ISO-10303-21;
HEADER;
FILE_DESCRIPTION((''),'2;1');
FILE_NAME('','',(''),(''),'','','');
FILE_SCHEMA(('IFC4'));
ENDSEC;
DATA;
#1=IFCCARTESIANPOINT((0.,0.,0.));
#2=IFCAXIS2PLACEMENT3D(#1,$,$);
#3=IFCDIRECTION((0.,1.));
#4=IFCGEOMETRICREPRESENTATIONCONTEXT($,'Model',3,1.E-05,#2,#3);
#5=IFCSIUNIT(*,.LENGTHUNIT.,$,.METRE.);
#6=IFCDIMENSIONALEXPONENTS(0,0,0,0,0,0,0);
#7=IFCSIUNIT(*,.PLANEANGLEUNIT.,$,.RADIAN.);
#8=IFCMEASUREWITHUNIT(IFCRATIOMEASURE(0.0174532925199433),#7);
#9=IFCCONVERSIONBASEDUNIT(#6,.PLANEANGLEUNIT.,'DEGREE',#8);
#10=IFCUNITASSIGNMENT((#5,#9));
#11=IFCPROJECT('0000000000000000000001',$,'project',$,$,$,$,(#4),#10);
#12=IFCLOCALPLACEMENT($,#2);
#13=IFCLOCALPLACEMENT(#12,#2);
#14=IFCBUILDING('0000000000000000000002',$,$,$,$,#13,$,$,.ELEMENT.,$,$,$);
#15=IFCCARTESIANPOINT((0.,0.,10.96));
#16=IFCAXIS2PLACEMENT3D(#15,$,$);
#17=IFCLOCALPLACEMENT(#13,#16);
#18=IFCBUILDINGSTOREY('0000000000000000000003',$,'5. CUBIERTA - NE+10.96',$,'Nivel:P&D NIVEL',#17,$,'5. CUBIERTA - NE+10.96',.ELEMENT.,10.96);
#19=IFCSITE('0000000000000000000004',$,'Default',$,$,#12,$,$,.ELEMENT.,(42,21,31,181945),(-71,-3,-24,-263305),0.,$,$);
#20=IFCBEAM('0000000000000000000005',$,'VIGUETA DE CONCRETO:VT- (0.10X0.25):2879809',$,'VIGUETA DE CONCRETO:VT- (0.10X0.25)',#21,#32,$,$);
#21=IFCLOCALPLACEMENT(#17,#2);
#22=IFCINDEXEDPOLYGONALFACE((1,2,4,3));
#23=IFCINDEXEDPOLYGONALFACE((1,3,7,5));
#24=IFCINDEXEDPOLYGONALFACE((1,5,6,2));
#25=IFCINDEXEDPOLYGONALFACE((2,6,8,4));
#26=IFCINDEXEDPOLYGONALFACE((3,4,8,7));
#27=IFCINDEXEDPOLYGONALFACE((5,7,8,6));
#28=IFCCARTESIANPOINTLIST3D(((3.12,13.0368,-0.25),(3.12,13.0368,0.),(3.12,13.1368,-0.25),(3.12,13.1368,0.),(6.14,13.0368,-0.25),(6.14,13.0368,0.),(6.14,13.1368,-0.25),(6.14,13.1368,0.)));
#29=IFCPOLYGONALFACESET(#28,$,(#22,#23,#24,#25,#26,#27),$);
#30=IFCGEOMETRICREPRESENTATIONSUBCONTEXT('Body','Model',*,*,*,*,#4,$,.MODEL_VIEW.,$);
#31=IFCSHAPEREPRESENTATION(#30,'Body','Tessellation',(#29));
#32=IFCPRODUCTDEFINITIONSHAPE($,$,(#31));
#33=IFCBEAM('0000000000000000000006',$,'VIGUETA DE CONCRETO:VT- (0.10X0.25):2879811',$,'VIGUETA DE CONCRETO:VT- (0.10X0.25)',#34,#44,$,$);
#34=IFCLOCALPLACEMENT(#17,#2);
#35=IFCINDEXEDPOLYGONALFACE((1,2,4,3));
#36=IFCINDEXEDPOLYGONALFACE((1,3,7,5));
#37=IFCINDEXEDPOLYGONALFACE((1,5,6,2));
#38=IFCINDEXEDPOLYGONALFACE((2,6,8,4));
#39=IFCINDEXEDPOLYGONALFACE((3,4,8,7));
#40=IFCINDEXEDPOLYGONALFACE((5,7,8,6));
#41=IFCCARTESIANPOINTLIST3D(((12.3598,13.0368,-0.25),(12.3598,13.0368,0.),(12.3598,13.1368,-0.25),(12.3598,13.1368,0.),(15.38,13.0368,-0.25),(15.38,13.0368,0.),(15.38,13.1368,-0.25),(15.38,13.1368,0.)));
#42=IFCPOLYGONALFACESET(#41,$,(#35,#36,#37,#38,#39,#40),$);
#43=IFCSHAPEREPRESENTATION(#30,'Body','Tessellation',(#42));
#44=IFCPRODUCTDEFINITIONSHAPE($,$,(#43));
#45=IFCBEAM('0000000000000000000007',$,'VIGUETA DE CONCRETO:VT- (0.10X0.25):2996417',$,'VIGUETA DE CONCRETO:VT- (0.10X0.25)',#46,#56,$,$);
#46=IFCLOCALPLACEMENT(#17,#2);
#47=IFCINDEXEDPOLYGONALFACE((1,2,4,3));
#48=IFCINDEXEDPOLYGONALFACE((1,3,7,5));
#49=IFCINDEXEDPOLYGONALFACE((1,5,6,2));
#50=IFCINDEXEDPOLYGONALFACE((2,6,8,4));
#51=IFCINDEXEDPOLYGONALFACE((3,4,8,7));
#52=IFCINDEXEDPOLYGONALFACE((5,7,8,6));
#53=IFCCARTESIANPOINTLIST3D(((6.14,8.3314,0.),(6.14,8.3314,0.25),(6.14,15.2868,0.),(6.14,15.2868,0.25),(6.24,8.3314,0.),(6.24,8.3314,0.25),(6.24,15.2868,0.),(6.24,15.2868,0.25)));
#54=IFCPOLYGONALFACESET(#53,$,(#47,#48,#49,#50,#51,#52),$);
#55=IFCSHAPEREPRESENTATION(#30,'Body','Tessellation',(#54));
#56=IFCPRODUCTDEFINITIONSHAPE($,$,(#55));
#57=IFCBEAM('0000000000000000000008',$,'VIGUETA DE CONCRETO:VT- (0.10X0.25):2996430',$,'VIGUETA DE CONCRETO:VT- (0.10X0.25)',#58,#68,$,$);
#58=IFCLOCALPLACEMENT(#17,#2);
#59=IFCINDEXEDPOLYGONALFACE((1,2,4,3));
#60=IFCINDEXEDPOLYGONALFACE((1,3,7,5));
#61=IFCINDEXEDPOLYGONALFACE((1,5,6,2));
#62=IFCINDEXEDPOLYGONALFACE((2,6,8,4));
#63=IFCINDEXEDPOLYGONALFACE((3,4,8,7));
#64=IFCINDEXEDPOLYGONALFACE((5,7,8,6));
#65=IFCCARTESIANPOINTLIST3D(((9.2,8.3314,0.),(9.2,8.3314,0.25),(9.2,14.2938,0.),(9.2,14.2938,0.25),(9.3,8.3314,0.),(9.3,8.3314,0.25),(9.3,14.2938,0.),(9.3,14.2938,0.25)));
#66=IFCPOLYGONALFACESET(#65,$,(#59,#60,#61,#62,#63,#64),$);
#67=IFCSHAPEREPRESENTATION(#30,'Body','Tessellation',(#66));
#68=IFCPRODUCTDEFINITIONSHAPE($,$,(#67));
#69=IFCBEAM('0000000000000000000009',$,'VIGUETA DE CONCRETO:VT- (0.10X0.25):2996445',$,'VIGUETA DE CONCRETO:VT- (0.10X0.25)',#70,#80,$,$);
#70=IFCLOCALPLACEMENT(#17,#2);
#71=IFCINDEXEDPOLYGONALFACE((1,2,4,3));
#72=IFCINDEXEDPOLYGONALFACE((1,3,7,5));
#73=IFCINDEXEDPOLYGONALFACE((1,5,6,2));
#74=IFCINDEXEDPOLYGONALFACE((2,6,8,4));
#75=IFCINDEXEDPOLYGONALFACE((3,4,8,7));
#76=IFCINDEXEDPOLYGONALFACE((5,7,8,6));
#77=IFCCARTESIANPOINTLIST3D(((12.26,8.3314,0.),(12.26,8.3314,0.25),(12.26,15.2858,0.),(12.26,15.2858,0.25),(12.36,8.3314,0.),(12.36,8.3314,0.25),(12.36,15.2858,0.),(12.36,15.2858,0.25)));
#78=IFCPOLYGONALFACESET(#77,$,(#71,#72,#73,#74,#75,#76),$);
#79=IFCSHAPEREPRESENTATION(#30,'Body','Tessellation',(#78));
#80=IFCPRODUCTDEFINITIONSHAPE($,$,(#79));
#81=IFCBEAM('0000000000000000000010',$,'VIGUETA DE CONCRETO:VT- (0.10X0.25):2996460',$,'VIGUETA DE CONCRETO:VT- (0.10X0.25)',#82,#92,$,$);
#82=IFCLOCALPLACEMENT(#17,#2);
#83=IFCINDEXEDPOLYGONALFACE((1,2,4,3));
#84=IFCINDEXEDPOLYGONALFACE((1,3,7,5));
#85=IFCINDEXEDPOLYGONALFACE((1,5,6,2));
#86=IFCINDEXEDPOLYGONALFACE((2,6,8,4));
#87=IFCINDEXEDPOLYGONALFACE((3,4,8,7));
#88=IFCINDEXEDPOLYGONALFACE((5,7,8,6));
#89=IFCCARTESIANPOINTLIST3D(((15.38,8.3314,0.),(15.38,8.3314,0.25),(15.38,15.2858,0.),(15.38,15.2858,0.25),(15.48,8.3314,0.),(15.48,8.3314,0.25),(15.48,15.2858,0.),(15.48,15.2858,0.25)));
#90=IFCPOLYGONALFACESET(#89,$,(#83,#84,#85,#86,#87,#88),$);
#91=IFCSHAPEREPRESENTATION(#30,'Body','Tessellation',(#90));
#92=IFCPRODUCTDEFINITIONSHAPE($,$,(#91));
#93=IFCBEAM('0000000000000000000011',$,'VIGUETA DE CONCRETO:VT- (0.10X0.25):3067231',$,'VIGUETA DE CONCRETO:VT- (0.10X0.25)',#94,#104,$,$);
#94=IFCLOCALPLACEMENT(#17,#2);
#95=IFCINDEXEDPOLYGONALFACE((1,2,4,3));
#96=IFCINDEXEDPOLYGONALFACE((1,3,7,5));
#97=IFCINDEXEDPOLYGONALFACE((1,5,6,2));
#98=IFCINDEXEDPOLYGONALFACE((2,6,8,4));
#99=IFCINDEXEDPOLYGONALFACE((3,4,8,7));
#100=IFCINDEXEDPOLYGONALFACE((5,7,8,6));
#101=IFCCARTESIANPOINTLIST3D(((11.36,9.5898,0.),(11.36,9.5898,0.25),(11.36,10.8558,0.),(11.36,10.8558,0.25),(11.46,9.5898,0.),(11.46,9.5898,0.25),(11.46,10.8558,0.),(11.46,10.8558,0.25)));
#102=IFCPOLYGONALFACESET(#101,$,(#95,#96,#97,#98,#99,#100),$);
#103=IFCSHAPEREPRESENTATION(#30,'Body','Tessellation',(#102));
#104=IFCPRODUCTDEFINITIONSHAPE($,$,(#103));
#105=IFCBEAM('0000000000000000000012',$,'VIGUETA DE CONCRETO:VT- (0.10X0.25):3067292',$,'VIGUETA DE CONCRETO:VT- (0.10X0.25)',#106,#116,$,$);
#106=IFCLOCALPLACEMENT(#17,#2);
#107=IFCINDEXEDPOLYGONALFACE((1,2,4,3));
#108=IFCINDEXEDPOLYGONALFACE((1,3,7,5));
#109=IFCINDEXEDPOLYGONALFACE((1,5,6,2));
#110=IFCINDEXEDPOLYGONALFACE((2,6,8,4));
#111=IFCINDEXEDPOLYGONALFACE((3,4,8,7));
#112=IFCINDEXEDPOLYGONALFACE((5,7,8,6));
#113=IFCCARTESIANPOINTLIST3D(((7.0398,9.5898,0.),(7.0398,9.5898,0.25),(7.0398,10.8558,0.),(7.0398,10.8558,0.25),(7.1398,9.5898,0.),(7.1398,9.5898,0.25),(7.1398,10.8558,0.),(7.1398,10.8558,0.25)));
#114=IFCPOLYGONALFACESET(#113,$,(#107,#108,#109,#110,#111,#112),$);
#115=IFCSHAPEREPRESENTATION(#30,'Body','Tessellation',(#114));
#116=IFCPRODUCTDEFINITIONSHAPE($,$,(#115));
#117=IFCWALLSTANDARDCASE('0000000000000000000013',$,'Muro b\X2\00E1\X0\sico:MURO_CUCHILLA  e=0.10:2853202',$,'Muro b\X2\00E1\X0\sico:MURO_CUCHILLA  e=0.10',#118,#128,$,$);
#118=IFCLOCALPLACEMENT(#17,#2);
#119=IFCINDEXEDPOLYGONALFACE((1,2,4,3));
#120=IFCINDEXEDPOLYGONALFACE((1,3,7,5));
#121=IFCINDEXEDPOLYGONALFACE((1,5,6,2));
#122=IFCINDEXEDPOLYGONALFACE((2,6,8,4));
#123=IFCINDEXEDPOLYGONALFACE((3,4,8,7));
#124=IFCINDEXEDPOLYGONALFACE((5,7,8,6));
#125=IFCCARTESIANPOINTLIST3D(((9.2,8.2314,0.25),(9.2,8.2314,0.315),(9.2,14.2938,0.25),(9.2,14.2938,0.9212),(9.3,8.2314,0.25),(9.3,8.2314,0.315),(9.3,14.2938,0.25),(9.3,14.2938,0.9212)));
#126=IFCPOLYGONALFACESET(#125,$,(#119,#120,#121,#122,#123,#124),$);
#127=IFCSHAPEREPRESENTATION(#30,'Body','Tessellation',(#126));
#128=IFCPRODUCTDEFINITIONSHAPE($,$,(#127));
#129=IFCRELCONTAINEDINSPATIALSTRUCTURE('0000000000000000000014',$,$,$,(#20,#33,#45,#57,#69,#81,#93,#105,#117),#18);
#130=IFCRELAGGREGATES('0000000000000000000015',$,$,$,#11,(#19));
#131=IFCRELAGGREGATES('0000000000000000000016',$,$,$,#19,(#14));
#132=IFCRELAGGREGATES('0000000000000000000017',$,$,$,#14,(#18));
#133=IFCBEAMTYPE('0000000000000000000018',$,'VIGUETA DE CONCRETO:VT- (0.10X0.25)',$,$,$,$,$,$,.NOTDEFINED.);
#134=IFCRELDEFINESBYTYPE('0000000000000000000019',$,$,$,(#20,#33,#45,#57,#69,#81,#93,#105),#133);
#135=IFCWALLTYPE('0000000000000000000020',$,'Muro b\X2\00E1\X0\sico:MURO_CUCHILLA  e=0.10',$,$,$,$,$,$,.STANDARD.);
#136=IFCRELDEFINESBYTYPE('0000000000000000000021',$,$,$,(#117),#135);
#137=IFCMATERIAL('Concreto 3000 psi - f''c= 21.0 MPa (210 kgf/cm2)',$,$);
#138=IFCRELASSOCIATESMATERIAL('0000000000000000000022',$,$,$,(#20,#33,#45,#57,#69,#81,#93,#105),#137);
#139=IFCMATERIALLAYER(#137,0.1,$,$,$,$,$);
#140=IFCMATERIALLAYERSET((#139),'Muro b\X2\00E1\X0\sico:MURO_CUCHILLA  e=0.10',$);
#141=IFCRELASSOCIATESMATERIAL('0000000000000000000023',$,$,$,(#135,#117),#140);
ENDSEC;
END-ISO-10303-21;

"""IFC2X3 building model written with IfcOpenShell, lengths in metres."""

from ifc_helpers import new_model, entity, si_unit, converted_unit, direction, frame, frame_2d, origin, place, context, subcontext, project, spatial, rectangle, extrude, clip, halfspace, material, layer, layer_set, layer_usage, type_object, element, save


model = new_model("IFC2X3")

# Units and contexts
model_context = context("Model", 3, precision=1e-05, world=origin(), true_north=direction((0.0, 1.0)))
body_context = subcontext(model_context, "Body", "Model", "MODEL_VIEW")
ifc_project = project(units=[si_unit("LENGTHUNIT", "METRE"), converted_unit("PLANEANGLEUNIT", "DEGREE", entity("IfcRatioMeasure", 0.0174532925199433), si_unit("PLANEANGLEUNIT", "RADIAN"), dimensions=[0, 0, 0, 0, 0, 0, 0])], contexts=[model_context])

# Site, building, storey
site_placement = place(None, origin())
site = spatial("IfcSite", under=ifc_project, at=site_placement, Name="Default", CompositionType="ELEMENT", RefLatitude=(42, 21, 31, 181945), RefLongitude=(-71, -3, -24, -263305), RefElevation=0.0)
building_placement = place(site_placement, origin())
building = spatial("IfcBuilding", under=site, at=building_placement, CompositionType="ELEMENT")
storey_placement = place(building_placement, frame((0.0, 0.0, 10.96)))
storey = spatial("IfcBuildingStorey", under=building, at=storey_placement, Name="5. CUBIERTA - NE+10.96", ObjectType="Nivel:P&D NIVEL", LongName="5. CUBIERTA - NE+10.96", CompositionType="ELEMENT", Elevation=10.96)

# Beams
ifc_material_1 = material(Name="Concreto 3000 psi - f'c= 21.0 MPa (210 kgf/cm2)")
beam_type_1 = type_object("IfcBeamType", Name="VIGUETA DE CONCRETO:VT- (0.10X0.25)", PredefinedType="NOTDEFINED")
beam_1_placement = place(storey_placement, frame((6.19, 13.0868, 0.0), z_axis=(0.0, 0.0, 1.0), x_axis=(-1.0, 0.0, 0.0)))
element("IfcBeam", 1, at=beam_1_placement, inside=storey, type_object=beam_type_1, material=ifc_material_1, Name="VIGUETA DE CONCRETO:VT- (0.10X0.25):2879809", ObjectType="VIGUETA DE CONCRETO:VT- (0.10X0.25)", context=body_context, shape_type="SweptSolid", body=[
    extrude(rectangle(XDim=0.25, YDim=0.1, at=frame_2d((0.0, 0.0), x_axis=(1.0, 0.0))), frame((0.05, 0.0, -0.125), z_axis=(1.0, 0.0, 0.0), x_axis=(0.0, 0.0, -1.0)), (0.0, 0.0, 1.0), 3.02),
])
beam_2_placement = place(storey_placement, frame((12.3098, 13.0868, 0.0)))
element("IfcBeam", 2, at=beam_2_placement, inside=storey, type_object=beam_type_1, material=ifc_material_1, Name="VIGUETA DE CONCRETO:VT- (0.10X0.25):2879811", ObjectType="VIGUETA DE CONCRETO:VT- (0.10X0.25)", context=body_context, shape_type="SweptSolid", body=[
    extrude(rectangle(XDim=0.25, YDim=0.1, at=frame_2d((0.0, 0.0), x_axis=(1.0, 0.0))), frame((0.05, 0.0, -0.125), z_axis=(1.0, 0.0, 0.0), x_axis=(0.0, 0.0, -1.0)), (0.0, 0.0, 1.0), 3.0202),
])
beam_3_placement = place(storey_placement, frame((6.19, 15.2868, 0.0), z_axis=(0.0, 0.0, 1.0), x_axis=(0.0, -1.0, 0.0)))
element("IfcBeam", 3, at=beam_3_placement, inside=storey, type_object=beam_type_1, material=ifc_material_1, Name="VIGUETA DE CONCRETO:VT- (0.10X0.25):2996417", ObjectType="VIGUETA DE CONCRETO:VT- (0.10X0.25)", context=body_context, shape_type="SweptSolid", body=[
    extrude(rectangle(XDim=0.25, YDim=0.1, at=frame_2d((0.0, 0.0), x_axis=(1.0, 0.0))), frame((0.0, 0.0, 0.125), z_axis=(1.0, 0.0, 0.0), x_axis=(0.0, 0.0, -1.0)), (0.0, 0.0, 1.0), 6.9554),
])
beam_4_placement = place(storey_placement, frame((9.25, 14.2938, 0.0), z_axis=(0.0, 0.0, 1.0), x_axis=(0.0, -1.0, 0.0)))
element("IfcBeam", 4, at=beam_4_placement, inside=storey, type_object=beam_type_1, material=ifc_material_1, Name="VIGUETA DE CONCRETO:VT- (0.10X0.25):2996430", ObjectType="VIGUETA DE CONCRETO:VT- (0.10X0.25)", context=body_context, shape_type="SweptSolid", body=[
    extrude(rectangle(XDim=0.25, YDim=0.1, at=frame_2d((0.0, 0.0), x_axis=(1.0, 0.0))), frame((0.0, 0.0, 0.125), z_axis=(1.0, 0.0, 0.0), x_axis=(0.0, 0.0, -1.0)), (0.0, 0.0, 1.0), 5.9624),
])
beam_5_placement = place(storey_placement, frame((12.31, 15.2858, 0.0), z_axis=(0.0, 0.0, 1.0), x_axis=(0.0, -1.0, 0.0)))
element("IfcBeam", 5, at=beam_5_placement, inside=storey, type_object=beam_type_1, material=ifc_material_1, Name="VIGUETA DE CONCRETO:VT- (0.10X0.25):2996445", ObjectType="VIGUETA DE CONCRETO:VT- (0.10X0.25)", context=body_context, shape_type="SweptSolid", body=[
    extrude(rectangle(XDim=0.25, YDim=0.1, at=frame_2d((0.0, 0.0), x_axis=(1.0, 0.0))), frame((0.0, 0.0, 0.125), z_axis=(1.0, 0.0, 0.0), x_axis=(0.0, 0.0, -1.0)), (0.0, 0.0, 1.0), 6.9544),
])
beam_6_placement = place(storey_placement, frame((15.43, 15.2858, 0.0), z_axis=(0.0, 0.0, 1.0), x_axis=(0.0, -1.0, 0.0)))
element("IfcBeam", 6, at=beam_6_placement, inside=storey, type_object=beam_type_1, material=ifc_material_1, Name="VIGUETA DE CONCRETO:VT- (0.10X0.25):2996460", ObjectType="VIGUETA DE CONCRETO:VT- (0.10X0.25)", context=body_context, shape_type="SweptSolid", body=[
    extrude(rectangle(XDim=0.25, YDim=0.1, at=frame_2d((0.0, 0.0), x_axis=(1.0, 0.0))), frame((0.0, 0.0, 0.125), z_axis=(1.0, 0.0, 0.0), x_axis=(0.0, 0.0, -1.0)), (0.0, 0.0, 1.0), 6.9544),
])
beam_7_placement = place(storey_placement, frame((11.41, 10.9058, 0.0), z_axis=(0.0, 0.0, 1.0), x_axis=(0.0, -1.0, 0.0)))
element("IfcBeam", 7, at=beam_7_placement, inside=storey, type_object=beam_type_1, material=ifc_material_1, Name="VIGUETA DE CONCRETO:VT- (0.10X0.25):3067231", ObjectType="VIGUETA DE CONCRETO:VT- (0.10X0.25)", context=body_context, shape_type="SweptSolid", body=[
    extrude(rectangle(XDim=0.25, YDim=0.1, at=frame_2d((0.0, 0.0), x_axis=(1.0, 0.0))), frame((0.05, 0.0, 0.125), z_axis=(1.0, 0.0, 0.0), x_axis=(0.0, 0.0, -1.0)), (0.0, 0.0, 1.0), 1.266),
])
beam_8_placement = place(storey_placement, frame((7.0898, 10.9058, 0.0), z_axis=(0.0, 0.0, 1.0), x_axis=(0.0, -1.0, 0.0)))
element("IfcBeam", 8, at=beam_8_placement, inside=storey, type_object=beam_type_1, material=ifc_material_1, Name="VIGUETA DE CONCRETO:VT- (0.10X0.25):3067292", ObjectType="VIGUETA DE CONCRETO:VT- (0.10X0.25)", context=body_context, shape_type="SweptSolid", body=[
    extrude(rectangle(XDim=0.25, YDim=0.1, at=frame_2d((0.0, 0.0), x_axis=(1.0, 0.0))), frame((0.05, 0.0, 0.125), z_axis=(1.0, 0.0, 0.0), x_axis=(0.0, 0.0, -1.0)), (0.0, 0.0, 1.0), 1.266),
])

# Wall
ifc_layer_1 = layer(ifc_material_1, 0.1)
ifc_layer_set_1 = layer_set([ifc_layer_1], Name="Muro básico:MURO_CUCHILLA  e=0.10")
ifc_layer_usage_1 = layer_usage(ifc_layer_set_1, "AXIS2", "POSITIVE", -0.05)
wall_type_1 = type_object("IfcWallType", Name="Muro básico:MURO_CUCHILLA  e=0.10", PredefinedType="STANDARD", material=ifc_layer_set_1)
wall_1_placement = place(storey_placement, frame((9.25, 8.2314, 0.25), z_axis=(0.0, 0.0, 1.0), x_axis=(0.0, 1.0, 0.0)))
element("IfcWallStandardCase", 9, at=wall_1_placement, inside=storey, type_object=wall_type_1, material=ifc_layer_usage_1, Name="Muro básico:MURO_CUCHILLA  e=0.10:2853202", ObjectType="Muro básico:MURO_CUCHILLA  e=0.10", context=body_context, shape_type="Clipping", body=[
    clip(extrude(rectangle(XDim=6.0624, YDim=0.1, at=frame_2d((3.0312, 0.0), x_axis=(-1.0, 0.0))), origin(), (0.0, 0.0, 1.0), 0.6712), halfspace(frame((0.0, -0.05, 0.065), z_axis=(-0.099504, 0.0, 0.995037), x_axis=(0.0, 1.0, 0.0)), False)),
])

save(model, "model.ifc")
